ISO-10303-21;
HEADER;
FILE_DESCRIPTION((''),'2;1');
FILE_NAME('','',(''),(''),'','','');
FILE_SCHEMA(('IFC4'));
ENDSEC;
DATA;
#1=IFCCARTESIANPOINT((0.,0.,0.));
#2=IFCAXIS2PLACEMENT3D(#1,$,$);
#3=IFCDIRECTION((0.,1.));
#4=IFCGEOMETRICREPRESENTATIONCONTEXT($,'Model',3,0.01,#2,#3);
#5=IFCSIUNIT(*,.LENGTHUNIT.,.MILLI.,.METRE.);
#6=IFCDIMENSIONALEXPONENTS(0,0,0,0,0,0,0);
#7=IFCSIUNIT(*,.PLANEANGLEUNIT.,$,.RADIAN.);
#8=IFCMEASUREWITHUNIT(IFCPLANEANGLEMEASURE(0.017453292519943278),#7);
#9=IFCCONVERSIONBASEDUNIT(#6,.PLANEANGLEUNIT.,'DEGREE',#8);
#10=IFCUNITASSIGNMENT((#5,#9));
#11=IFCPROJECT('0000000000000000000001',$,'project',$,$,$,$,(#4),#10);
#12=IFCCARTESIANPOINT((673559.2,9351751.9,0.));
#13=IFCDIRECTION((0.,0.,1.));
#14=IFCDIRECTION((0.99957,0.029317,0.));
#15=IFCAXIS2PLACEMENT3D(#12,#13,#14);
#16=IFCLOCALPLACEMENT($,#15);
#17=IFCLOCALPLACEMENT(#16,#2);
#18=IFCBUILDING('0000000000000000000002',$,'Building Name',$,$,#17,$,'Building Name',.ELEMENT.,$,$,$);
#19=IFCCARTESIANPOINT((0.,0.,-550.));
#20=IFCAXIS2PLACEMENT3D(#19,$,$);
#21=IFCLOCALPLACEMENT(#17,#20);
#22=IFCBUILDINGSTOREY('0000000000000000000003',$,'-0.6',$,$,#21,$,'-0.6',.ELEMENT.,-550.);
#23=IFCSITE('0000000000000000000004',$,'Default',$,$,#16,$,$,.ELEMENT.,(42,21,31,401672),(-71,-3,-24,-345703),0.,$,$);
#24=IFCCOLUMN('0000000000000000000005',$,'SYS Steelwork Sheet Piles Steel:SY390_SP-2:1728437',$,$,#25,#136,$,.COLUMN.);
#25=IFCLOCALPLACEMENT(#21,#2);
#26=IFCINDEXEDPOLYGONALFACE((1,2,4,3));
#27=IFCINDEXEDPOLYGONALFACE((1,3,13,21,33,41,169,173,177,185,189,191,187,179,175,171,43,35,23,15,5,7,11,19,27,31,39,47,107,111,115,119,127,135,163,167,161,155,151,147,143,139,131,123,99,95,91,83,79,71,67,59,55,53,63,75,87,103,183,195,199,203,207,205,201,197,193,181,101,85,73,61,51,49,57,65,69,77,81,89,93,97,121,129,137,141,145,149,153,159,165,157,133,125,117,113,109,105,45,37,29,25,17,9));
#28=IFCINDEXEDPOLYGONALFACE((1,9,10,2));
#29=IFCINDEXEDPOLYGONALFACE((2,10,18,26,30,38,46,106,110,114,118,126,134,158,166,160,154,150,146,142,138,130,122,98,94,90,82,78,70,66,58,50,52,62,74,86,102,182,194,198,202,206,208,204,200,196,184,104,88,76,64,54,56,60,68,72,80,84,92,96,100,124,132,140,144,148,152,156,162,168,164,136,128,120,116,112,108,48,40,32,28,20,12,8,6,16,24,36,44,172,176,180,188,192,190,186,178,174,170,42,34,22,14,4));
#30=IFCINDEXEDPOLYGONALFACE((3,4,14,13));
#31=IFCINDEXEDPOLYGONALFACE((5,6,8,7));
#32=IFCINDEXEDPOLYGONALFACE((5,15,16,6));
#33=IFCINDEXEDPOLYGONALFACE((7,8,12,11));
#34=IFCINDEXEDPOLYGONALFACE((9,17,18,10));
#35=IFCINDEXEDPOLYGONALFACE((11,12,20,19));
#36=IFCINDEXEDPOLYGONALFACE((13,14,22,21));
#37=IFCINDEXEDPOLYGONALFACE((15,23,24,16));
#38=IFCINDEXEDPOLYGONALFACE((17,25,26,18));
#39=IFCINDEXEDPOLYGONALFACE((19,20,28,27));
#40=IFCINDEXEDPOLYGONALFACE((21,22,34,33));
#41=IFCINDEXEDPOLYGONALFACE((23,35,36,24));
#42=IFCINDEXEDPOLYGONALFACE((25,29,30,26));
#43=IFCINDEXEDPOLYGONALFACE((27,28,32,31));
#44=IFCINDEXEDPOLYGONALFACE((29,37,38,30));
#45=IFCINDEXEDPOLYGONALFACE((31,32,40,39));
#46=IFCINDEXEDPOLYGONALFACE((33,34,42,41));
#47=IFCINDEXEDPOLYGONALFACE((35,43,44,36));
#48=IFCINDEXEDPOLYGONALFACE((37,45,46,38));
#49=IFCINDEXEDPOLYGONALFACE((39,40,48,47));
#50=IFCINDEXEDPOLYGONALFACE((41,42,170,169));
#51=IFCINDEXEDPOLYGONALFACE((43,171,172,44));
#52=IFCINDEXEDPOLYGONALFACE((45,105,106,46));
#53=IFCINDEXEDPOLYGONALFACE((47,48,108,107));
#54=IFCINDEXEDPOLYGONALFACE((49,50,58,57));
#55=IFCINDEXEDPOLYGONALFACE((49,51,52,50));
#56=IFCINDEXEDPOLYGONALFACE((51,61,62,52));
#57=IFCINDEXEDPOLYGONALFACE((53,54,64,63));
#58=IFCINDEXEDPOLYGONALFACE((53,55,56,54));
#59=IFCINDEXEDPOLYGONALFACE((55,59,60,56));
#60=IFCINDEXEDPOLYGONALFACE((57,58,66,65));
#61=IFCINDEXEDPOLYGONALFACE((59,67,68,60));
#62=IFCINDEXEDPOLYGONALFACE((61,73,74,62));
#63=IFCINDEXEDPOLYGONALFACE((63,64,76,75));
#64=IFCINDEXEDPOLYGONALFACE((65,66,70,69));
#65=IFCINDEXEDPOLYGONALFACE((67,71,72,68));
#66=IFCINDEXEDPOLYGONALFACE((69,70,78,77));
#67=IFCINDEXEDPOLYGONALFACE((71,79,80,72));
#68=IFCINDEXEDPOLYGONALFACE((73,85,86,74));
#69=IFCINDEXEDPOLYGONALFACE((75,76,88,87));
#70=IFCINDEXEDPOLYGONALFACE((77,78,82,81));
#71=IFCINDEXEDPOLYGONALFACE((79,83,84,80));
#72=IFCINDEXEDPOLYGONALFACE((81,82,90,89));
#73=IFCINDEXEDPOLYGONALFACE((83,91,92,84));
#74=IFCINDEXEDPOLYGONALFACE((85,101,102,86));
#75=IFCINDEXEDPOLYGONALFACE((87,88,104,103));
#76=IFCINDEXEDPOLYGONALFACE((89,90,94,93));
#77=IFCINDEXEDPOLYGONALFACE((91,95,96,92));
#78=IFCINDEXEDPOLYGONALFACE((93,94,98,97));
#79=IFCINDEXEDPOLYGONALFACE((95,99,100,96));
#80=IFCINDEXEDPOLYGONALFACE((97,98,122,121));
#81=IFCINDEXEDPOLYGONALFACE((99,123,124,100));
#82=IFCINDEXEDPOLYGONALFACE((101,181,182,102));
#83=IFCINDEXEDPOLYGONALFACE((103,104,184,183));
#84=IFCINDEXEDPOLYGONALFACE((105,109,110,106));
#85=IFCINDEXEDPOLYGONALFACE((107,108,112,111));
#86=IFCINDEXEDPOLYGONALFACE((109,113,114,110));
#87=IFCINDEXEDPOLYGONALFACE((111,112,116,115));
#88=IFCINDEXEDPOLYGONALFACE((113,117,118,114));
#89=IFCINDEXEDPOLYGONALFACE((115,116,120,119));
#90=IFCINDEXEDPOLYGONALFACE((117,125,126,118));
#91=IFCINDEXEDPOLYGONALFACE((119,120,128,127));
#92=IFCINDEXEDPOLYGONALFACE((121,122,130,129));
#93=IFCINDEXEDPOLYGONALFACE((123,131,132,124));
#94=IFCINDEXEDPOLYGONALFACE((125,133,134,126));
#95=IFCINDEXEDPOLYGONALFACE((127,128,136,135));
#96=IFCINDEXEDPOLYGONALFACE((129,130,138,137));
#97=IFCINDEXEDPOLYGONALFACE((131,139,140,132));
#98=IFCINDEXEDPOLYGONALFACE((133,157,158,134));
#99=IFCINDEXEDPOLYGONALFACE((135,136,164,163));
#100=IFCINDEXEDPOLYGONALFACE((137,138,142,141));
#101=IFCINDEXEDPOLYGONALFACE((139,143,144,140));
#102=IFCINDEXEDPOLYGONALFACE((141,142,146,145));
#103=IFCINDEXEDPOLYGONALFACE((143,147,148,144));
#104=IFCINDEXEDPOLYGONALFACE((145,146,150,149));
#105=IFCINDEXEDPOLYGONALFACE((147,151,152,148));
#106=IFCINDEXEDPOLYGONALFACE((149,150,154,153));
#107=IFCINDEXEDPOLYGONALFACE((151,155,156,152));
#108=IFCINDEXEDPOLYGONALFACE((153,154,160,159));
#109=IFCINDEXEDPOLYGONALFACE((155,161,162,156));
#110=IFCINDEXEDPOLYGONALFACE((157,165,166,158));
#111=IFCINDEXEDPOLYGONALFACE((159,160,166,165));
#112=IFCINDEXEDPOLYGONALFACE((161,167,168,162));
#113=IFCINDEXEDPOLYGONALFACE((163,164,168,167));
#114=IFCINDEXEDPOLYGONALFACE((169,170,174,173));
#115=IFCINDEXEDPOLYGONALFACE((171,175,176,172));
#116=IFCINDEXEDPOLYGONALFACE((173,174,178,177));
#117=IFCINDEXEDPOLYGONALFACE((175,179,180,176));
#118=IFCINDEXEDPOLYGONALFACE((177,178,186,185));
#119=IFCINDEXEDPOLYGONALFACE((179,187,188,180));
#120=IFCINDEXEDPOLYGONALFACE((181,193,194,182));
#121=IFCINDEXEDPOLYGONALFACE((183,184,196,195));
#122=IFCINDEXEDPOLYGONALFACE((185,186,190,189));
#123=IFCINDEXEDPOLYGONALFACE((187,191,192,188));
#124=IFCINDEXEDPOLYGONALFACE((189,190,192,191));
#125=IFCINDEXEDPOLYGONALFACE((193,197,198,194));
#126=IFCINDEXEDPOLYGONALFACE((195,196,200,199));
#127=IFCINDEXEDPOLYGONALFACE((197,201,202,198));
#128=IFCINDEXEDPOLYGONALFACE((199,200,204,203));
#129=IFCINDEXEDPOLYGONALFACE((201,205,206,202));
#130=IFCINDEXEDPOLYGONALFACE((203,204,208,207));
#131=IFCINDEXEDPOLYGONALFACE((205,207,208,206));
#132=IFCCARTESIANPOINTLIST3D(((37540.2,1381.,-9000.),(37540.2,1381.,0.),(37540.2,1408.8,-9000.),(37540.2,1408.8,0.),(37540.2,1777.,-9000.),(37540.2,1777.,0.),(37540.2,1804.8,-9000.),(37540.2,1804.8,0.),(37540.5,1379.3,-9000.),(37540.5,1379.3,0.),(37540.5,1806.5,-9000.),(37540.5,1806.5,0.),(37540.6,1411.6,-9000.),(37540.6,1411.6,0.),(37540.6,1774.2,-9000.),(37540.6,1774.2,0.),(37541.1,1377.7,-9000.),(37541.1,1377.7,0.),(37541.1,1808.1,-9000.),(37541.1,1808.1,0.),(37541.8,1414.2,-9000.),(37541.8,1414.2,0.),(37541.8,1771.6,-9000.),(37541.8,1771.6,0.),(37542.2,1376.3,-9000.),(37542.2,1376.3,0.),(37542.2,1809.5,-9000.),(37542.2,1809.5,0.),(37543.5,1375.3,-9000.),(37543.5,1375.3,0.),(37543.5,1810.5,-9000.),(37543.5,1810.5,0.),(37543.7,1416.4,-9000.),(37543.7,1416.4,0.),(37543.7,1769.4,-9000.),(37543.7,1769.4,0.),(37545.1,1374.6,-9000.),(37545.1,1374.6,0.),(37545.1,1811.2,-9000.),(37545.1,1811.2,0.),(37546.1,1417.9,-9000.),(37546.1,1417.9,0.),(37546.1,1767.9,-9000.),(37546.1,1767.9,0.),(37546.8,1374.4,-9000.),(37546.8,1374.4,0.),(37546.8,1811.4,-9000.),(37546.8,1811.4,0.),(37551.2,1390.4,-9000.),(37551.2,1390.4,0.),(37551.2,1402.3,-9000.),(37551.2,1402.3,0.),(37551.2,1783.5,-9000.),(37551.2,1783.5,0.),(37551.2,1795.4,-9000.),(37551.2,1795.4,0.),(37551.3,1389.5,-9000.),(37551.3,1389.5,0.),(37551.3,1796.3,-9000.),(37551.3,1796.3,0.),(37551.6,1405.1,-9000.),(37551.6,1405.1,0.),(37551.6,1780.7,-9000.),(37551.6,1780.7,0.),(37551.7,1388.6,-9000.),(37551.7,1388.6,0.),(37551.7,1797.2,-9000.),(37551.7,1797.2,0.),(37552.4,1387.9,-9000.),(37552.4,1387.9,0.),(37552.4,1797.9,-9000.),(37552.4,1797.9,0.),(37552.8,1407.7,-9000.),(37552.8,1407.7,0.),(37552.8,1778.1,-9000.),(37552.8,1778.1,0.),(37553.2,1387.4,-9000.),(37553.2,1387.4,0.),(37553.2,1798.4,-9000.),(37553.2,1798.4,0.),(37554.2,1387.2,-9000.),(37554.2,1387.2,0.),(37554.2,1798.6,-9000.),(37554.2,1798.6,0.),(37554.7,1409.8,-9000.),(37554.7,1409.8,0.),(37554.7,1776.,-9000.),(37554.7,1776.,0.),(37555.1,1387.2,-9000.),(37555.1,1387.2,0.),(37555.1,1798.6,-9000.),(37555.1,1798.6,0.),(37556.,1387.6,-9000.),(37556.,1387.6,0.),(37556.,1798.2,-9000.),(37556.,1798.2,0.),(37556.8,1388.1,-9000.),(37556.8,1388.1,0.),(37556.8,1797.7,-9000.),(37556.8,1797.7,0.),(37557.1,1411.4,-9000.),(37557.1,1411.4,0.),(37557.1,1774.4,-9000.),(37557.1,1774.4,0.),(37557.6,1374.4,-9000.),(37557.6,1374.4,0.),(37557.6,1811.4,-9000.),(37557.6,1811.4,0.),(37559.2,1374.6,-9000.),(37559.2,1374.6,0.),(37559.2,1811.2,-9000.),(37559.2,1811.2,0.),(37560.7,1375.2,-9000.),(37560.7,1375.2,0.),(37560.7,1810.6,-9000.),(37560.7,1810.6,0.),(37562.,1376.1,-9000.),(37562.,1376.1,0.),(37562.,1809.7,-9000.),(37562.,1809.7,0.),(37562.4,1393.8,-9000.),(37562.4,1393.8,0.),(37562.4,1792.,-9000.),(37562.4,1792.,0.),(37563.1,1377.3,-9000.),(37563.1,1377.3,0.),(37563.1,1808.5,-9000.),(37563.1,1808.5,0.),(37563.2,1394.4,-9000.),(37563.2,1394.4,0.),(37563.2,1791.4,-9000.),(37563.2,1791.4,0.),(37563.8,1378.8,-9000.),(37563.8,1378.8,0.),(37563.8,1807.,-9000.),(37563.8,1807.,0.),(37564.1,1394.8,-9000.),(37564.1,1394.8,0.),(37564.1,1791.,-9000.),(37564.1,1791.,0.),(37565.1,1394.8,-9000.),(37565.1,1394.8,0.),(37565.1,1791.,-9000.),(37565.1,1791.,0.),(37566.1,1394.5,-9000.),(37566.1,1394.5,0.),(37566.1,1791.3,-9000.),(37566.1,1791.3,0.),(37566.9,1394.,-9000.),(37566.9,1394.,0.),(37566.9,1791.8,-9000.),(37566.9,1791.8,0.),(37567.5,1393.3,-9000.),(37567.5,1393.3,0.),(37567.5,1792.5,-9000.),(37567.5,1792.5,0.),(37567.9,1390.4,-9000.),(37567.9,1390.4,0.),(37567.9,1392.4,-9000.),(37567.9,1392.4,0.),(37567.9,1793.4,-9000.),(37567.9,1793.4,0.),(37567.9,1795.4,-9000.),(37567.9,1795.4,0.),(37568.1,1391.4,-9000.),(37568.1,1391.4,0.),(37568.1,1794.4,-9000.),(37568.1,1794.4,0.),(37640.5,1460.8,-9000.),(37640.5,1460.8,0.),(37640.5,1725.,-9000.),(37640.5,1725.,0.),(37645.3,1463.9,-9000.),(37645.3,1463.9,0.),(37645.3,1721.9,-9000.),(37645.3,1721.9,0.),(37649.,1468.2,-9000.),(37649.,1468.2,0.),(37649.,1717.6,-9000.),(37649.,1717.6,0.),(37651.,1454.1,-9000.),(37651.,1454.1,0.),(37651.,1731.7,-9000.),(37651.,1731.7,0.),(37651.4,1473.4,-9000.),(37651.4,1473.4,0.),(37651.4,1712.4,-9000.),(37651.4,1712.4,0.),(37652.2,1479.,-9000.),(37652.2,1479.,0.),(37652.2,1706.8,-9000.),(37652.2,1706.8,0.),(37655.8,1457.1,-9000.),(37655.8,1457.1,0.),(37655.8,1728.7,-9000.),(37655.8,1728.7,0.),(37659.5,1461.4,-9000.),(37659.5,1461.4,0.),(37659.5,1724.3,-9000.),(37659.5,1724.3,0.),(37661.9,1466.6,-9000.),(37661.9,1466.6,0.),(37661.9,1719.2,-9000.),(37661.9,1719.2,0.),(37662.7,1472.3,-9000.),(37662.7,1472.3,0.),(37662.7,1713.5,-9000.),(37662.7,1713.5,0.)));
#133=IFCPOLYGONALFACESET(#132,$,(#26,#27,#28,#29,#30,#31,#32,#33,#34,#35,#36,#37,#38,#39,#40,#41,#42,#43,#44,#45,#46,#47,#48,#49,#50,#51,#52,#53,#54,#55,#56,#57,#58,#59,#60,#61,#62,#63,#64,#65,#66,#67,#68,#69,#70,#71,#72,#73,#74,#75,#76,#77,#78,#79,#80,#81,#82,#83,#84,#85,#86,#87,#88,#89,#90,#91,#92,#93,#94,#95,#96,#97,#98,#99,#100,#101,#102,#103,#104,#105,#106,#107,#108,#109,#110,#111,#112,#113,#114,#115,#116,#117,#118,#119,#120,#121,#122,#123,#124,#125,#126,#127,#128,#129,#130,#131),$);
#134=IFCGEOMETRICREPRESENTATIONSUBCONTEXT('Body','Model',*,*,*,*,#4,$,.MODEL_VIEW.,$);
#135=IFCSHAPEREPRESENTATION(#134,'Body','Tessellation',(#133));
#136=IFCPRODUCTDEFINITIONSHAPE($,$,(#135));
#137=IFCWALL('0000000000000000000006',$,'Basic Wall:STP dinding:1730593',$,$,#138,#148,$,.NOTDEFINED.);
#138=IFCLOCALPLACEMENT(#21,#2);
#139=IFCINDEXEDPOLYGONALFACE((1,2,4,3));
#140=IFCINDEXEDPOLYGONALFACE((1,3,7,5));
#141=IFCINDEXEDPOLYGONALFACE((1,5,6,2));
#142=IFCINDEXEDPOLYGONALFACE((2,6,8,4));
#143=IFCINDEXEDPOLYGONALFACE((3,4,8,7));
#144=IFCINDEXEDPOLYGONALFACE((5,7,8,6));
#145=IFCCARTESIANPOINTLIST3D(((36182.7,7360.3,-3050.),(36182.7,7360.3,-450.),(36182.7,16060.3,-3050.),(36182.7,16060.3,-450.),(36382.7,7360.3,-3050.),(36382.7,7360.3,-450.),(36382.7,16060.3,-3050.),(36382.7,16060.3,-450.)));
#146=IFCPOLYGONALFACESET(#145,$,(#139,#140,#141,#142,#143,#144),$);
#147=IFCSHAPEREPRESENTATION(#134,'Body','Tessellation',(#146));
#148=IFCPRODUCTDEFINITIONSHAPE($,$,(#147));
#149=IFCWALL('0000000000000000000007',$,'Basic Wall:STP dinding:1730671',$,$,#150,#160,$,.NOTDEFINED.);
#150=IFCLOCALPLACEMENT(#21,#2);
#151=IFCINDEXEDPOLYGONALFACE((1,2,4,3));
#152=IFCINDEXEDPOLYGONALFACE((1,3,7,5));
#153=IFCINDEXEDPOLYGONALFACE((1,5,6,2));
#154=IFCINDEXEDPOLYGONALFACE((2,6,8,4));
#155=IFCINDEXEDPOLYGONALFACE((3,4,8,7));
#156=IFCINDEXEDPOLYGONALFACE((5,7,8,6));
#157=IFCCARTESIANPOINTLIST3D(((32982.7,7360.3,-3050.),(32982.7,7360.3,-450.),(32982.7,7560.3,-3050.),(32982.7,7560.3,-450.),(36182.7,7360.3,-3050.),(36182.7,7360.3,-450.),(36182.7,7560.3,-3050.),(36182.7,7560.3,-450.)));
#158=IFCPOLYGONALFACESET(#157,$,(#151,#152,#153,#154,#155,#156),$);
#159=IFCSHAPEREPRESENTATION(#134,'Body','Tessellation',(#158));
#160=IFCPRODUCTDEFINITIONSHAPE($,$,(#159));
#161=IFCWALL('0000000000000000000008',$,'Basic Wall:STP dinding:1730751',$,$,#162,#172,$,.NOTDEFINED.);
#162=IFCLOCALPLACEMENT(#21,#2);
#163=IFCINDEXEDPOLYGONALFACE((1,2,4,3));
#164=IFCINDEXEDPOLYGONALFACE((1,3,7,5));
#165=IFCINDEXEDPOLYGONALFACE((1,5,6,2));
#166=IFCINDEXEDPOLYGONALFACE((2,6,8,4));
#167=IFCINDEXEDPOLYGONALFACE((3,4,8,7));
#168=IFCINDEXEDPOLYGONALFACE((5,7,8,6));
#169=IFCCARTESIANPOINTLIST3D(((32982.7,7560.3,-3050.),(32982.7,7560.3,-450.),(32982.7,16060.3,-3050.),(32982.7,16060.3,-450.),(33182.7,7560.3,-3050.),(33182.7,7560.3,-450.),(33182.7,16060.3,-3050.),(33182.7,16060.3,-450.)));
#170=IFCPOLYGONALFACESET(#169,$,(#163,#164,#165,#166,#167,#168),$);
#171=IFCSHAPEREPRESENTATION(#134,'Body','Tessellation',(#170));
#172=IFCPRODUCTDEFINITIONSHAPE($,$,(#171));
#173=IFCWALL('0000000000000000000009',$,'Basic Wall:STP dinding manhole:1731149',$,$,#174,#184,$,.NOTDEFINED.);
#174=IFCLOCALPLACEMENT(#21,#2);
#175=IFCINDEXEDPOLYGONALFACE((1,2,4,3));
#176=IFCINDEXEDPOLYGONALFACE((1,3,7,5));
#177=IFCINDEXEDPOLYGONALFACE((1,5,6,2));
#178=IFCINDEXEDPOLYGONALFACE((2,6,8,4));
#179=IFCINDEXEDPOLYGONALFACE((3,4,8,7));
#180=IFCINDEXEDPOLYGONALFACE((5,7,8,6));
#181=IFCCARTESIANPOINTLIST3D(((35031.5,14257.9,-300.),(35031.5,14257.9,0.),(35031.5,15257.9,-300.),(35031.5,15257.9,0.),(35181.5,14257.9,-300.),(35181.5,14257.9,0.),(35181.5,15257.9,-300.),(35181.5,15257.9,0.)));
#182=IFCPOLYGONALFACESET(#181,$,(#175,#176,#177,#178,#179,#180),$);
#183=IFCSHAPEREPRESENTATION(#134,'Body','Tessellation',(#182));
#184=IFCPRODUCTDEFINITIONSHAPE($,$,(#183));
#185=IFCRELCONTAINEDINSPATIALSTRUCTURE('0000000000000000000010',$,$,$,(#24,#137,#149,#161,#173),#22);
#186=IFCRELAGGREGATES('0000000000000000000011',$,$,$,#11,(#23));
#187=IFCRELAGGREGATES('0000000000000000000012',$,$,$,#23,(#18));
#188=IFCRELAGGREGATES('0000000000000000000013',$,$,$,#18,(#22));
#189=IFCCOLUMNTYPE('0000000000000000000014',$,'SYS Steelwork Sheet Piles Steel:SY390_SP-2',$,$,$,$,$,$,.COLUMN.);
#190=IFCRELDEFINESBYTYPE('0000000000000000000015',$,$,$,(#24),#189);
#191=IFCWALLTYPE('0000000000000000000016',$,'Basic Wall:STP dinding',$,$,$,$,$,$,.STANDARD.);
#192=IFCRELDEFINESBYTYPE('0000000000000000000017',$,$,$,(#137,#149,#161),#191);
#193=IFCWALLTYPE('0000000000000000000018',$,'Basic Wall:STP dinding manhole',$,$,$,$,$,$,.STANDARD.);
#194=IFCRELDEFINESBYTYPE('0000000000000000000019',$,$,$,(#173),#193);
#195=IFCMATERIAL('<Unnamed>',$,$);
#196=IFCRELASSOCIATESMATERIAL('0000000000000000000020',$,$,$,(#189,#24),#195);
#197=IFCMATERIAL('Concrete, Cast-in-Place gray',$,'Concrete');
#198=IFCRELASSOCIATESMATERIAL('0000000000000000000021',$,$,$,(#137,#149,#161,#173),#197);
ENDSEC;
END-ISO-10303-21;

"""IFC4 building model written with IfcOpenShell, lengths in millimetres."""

from ifc_helpers import new_model, entity, si_unit, converted_unit, direction, frame, origin, place, context, subcontext, project, spatial, line, arc, indexed_curve, outline, extrude, source, transform, mapped, material, type_object, type_shapes, element, save


model = new_model("IFC4")

# Units and contexts
model_context = context("Model", 3, precision=0.01, world=origin(), true_north=direction((0.0, 1.0)))
body_context = subcontext(model_context, "Body", "Model", "MODEL_VIEW")
ifc_project = project(units=[si_unit("LENGTHUNIT", "METRE", prefix="MILLI"), converted_unit("PLANEANGLEUNIT", "DEGREE", entity("IfcPlaneAngleMeasure", 0.017453292519943278), si_unit("PLANEANGLEUNIT", "RADIAN"), dimensions=[0, 0, 0, 0, 0, 0, 0])], contexts=[model_context])

# Site, building, storey
site_placement = place(None, frame((673559.2, 9351751.9, 0.0), z_axis=(0.0, 0.0, 1.0), x_axis=(0.99957, 0.029317, 0.0)))
site = spatial("IfcSite", under=ifc_project, at=site_placement, Name="Default", CompositionType="ELEMENT", RefLatitude=(42, 21, 31, 401672), RefLongitude=(-71, -3, -24, -345703), RefElevation=0.0)
building_placement = place(site_placement, origin())
building = spatial("IfcBuilding", under=site, at=building_placement, Name="Building Name", LongName="Building Name", CompositionType="ELEMENT")
storey_placement = place(building_placement, frame((0.0, 0.0, -550.0)))
storey = spatial("IfcBuildingStorey", under=building, at=storey_placement, Name="-0.6", LongName="-0.6", CompositionType="ELEMENT", Elevation=-550.0)

# Column
ifc_material_1 = material(Name="<Unnamed>")
column_type = type_object("IfcColumnType", Name="SYS Steelwork Sheet Piles Steel:SY390_SP-2", PredefinedType="COLUMN", material=ifc_material_1)
shared_shape = source(origin(), body_context, "Body", "SweptSolid", [
    extrude(outline(indexed_curve([(-120.6, 84.7), (-131.4, 81.6), (-138.8, 73.0), (-181.5, -20.9), (-185.2, -25.2), (-190.6, -26.8), (-202.5, -26.8), (-205.5, -24.8), (-204.8, -21.2), (-199.1, -15.5), (-198.6, -11.5), (-202.5, -10.1), (-214.1, -14.2), (-217.3, -16.6), (-218.5, -20.4), (-218.5, -31.2), (-216.6, -35.8), (-211.9, -37.8), (-184.1, -37.8), (-178.7, -36.2), (-175.0, -31.9), (-132.1, 62.5), (-124.7, 71.1), (-113.9, 74.2), (113.9, 74.2), (124.7, 71.1), (132.1, 62.5), (175.0, -31.9), (178.7, -36.2), (184.1, -37.8), (211.9, -37.8), (216.6, -35.8), (218.5, -31.2), (218.5, -20.4), (217.3, -16.6), (214.1, -14.2), (202.5, -10.1), (198.6, -11.5), (199.1, -15.5), (204.8, -21.2), (205.5, -24.8), (202.5, -26.8), (190.6, -26.8), (185.2, -25.2), (181.5, -20.9), (138.8, 73.0), (131.4, 81.6), (120.6, 84.7)], segments=[arc(1, 2, 3), line(3, 4), arc(4, 5, 6), line(6, 7), arc(7, 8, 9), line(9, 10), arc(10, 11, 12), line(12, 13), arc(13, 14, 15), line(15, 16), arc(16, 17, 18), line(18, 19), arc(19, 20, 21), line(21, 22), arc(22, 23, 24), line(24, 25), arc(25, 26, 27), line(27, 28), arc(28, 29, 30), line(30, 31), arc(31, 32, 33), line(33, 34), arc(34, 35, 36), line(36, 37), arc(37, 38, 39), line(39, 40), arc(40, 41, 42), line(42, 43), arc(43, 44, 45), line(45, 46), arc(46, 47, 48), line(48, 1)], self_intersect=False)), frame((0.0, 15.3, -9550.0)), (0.0, 0.0, 1.0), 9000.0),
])
type_shapes(column_type, [shared_shape])
for number, where, z_axis, x_axis, name in (
    (1, (37562.7, 1592.9, 550.0), (0.0, 0.0, 1.0), (0.0, -1.0, 0.0), "SYS Steelwork Sheet Piles Steel:SY390_SP-2:1728437"),
):
    element("IfcColumn", number, at=place(storey_placement, frame(where, z_axis=z_axis, x_axis=x_axis)), inside=storey, type_object=column_type, material=ifc_material_1, Name=name, PredefinedType="COLUMN", context=body_context, shape_type="MappedRepresentation", body=[
        mapped(shared_shape, transform((0.0, 0.0, 0.0), scale=1.0)),
    ])

# Walls
ifc_material_2 = material(Name="Concrete, Cast-in-Place gray", Category="Concrete")
wall_type_1 = type_object("IfcWallType", Name="Basic Wall:STP dinding", PredefinedType="STANDARD")
wall_1_placement = place(storey_placement, frame((36282.7, 16060.3, -3050.0), z_axis=(0.0, 0.0, 1.0), x_axis=(0.0, -1.0, 0.0)))
element("IfcWall", 2, at=wall_1_placement, inside=storey, type_object=wall_type_1, material=ifc_material_2, Name="Basic Wall:STP dinding:1730593", PredefinedType="NOTDEFINED", context=body_context, shape_type="SweptSolid", body=[
    extrude(outline(indexed_curve([(8700.0, 100.0), (0.0, 100.0), (0.0, -100.0), (8700.0, -100.0), (8700.0, 100.0)], self_intersect=False)), origin(), (0.0, 0.0, 1.0), 2600.0),
])
wall_2_placement = place(storey_placement, frame((36182.7, 7460.3, -3050.0), z_axis=(0.0, 0.0, 1.0), x_axis=(-1.0, 0.0, 0.0)))
element("IfcWall", 3, at=wall_2_placement, inside=storey, type_object=wall_type_1, material=ifc_material_2, Name="Basic Wall:STP dinding:1730671", PredefinedType="NOTDEFINED", context=body_context, shape_type="SweptSolid", body=[
    extrude(outline(indexed_curve([(3200.0, 100.0), (0.0, 100.0), (0.0, -100.0), (3200.0, -100.0), (3200.0, 100.0)], self_intersect=False)), origin(), (0.0, 0.0, 1.0), 2600.0),
])
wall_3_placement = place(storey_placement, frame((33082.7, 7560.3, -3050.0), z_axis=(0.0, 0.0, 1.0), x_axis=(0.0, 1.0, 0.0)))
element("IfcWall", 4, at=wall_3_placement, inside=storey, type_object=wall_type_1, material=ifc_material_2, Name="Basic Wall:STP dinding:1730751", PredefinedType="NOTDEFINED", context=body_context, shape_type="SweptSolid", body=[
    extrude(outline(indexed_curve([(8500.0, 100.0), (0.0, 100.0), (0.0, -100.0), (8500.0, -100.0), (8500.0, 100.0)], self_intersect=False)), origin(), (0.0, 0.0, 1.0), 2600.0),
])
wall_type_2 = type_object("IfcWallType", Name="Basic Wall:STP dinding manhole", PredefinedType="STANDARD")
wall_4_placement = place(storey_placement, frame((35106.5, 15257.9, -300.0), z_axis=(0.0, 0.0, 1.0), x_axis=(0.0, -1.0, 0.0)))
element("IfcWall", 5, at=wall_4_placement, inside=storey, type_object=wall_type_2, material=ifc_material_2, Name="Basic Wall:STP dinding manhole:1731149", PredefinedType="NOTDEFINED", context=body_context, shape_type="SweptSolid", body=[
    extrude(outline(indexed_curve([(1000.0, 75.0), (0.0, 75.0), (0.0, -75.0), (1000.0, -75.0), (1000.0, 75.0)], self_intersect=False)), origin(), (0.0, 0.0, 1.0), 300.0),
])

save(model, "model.ifc")
